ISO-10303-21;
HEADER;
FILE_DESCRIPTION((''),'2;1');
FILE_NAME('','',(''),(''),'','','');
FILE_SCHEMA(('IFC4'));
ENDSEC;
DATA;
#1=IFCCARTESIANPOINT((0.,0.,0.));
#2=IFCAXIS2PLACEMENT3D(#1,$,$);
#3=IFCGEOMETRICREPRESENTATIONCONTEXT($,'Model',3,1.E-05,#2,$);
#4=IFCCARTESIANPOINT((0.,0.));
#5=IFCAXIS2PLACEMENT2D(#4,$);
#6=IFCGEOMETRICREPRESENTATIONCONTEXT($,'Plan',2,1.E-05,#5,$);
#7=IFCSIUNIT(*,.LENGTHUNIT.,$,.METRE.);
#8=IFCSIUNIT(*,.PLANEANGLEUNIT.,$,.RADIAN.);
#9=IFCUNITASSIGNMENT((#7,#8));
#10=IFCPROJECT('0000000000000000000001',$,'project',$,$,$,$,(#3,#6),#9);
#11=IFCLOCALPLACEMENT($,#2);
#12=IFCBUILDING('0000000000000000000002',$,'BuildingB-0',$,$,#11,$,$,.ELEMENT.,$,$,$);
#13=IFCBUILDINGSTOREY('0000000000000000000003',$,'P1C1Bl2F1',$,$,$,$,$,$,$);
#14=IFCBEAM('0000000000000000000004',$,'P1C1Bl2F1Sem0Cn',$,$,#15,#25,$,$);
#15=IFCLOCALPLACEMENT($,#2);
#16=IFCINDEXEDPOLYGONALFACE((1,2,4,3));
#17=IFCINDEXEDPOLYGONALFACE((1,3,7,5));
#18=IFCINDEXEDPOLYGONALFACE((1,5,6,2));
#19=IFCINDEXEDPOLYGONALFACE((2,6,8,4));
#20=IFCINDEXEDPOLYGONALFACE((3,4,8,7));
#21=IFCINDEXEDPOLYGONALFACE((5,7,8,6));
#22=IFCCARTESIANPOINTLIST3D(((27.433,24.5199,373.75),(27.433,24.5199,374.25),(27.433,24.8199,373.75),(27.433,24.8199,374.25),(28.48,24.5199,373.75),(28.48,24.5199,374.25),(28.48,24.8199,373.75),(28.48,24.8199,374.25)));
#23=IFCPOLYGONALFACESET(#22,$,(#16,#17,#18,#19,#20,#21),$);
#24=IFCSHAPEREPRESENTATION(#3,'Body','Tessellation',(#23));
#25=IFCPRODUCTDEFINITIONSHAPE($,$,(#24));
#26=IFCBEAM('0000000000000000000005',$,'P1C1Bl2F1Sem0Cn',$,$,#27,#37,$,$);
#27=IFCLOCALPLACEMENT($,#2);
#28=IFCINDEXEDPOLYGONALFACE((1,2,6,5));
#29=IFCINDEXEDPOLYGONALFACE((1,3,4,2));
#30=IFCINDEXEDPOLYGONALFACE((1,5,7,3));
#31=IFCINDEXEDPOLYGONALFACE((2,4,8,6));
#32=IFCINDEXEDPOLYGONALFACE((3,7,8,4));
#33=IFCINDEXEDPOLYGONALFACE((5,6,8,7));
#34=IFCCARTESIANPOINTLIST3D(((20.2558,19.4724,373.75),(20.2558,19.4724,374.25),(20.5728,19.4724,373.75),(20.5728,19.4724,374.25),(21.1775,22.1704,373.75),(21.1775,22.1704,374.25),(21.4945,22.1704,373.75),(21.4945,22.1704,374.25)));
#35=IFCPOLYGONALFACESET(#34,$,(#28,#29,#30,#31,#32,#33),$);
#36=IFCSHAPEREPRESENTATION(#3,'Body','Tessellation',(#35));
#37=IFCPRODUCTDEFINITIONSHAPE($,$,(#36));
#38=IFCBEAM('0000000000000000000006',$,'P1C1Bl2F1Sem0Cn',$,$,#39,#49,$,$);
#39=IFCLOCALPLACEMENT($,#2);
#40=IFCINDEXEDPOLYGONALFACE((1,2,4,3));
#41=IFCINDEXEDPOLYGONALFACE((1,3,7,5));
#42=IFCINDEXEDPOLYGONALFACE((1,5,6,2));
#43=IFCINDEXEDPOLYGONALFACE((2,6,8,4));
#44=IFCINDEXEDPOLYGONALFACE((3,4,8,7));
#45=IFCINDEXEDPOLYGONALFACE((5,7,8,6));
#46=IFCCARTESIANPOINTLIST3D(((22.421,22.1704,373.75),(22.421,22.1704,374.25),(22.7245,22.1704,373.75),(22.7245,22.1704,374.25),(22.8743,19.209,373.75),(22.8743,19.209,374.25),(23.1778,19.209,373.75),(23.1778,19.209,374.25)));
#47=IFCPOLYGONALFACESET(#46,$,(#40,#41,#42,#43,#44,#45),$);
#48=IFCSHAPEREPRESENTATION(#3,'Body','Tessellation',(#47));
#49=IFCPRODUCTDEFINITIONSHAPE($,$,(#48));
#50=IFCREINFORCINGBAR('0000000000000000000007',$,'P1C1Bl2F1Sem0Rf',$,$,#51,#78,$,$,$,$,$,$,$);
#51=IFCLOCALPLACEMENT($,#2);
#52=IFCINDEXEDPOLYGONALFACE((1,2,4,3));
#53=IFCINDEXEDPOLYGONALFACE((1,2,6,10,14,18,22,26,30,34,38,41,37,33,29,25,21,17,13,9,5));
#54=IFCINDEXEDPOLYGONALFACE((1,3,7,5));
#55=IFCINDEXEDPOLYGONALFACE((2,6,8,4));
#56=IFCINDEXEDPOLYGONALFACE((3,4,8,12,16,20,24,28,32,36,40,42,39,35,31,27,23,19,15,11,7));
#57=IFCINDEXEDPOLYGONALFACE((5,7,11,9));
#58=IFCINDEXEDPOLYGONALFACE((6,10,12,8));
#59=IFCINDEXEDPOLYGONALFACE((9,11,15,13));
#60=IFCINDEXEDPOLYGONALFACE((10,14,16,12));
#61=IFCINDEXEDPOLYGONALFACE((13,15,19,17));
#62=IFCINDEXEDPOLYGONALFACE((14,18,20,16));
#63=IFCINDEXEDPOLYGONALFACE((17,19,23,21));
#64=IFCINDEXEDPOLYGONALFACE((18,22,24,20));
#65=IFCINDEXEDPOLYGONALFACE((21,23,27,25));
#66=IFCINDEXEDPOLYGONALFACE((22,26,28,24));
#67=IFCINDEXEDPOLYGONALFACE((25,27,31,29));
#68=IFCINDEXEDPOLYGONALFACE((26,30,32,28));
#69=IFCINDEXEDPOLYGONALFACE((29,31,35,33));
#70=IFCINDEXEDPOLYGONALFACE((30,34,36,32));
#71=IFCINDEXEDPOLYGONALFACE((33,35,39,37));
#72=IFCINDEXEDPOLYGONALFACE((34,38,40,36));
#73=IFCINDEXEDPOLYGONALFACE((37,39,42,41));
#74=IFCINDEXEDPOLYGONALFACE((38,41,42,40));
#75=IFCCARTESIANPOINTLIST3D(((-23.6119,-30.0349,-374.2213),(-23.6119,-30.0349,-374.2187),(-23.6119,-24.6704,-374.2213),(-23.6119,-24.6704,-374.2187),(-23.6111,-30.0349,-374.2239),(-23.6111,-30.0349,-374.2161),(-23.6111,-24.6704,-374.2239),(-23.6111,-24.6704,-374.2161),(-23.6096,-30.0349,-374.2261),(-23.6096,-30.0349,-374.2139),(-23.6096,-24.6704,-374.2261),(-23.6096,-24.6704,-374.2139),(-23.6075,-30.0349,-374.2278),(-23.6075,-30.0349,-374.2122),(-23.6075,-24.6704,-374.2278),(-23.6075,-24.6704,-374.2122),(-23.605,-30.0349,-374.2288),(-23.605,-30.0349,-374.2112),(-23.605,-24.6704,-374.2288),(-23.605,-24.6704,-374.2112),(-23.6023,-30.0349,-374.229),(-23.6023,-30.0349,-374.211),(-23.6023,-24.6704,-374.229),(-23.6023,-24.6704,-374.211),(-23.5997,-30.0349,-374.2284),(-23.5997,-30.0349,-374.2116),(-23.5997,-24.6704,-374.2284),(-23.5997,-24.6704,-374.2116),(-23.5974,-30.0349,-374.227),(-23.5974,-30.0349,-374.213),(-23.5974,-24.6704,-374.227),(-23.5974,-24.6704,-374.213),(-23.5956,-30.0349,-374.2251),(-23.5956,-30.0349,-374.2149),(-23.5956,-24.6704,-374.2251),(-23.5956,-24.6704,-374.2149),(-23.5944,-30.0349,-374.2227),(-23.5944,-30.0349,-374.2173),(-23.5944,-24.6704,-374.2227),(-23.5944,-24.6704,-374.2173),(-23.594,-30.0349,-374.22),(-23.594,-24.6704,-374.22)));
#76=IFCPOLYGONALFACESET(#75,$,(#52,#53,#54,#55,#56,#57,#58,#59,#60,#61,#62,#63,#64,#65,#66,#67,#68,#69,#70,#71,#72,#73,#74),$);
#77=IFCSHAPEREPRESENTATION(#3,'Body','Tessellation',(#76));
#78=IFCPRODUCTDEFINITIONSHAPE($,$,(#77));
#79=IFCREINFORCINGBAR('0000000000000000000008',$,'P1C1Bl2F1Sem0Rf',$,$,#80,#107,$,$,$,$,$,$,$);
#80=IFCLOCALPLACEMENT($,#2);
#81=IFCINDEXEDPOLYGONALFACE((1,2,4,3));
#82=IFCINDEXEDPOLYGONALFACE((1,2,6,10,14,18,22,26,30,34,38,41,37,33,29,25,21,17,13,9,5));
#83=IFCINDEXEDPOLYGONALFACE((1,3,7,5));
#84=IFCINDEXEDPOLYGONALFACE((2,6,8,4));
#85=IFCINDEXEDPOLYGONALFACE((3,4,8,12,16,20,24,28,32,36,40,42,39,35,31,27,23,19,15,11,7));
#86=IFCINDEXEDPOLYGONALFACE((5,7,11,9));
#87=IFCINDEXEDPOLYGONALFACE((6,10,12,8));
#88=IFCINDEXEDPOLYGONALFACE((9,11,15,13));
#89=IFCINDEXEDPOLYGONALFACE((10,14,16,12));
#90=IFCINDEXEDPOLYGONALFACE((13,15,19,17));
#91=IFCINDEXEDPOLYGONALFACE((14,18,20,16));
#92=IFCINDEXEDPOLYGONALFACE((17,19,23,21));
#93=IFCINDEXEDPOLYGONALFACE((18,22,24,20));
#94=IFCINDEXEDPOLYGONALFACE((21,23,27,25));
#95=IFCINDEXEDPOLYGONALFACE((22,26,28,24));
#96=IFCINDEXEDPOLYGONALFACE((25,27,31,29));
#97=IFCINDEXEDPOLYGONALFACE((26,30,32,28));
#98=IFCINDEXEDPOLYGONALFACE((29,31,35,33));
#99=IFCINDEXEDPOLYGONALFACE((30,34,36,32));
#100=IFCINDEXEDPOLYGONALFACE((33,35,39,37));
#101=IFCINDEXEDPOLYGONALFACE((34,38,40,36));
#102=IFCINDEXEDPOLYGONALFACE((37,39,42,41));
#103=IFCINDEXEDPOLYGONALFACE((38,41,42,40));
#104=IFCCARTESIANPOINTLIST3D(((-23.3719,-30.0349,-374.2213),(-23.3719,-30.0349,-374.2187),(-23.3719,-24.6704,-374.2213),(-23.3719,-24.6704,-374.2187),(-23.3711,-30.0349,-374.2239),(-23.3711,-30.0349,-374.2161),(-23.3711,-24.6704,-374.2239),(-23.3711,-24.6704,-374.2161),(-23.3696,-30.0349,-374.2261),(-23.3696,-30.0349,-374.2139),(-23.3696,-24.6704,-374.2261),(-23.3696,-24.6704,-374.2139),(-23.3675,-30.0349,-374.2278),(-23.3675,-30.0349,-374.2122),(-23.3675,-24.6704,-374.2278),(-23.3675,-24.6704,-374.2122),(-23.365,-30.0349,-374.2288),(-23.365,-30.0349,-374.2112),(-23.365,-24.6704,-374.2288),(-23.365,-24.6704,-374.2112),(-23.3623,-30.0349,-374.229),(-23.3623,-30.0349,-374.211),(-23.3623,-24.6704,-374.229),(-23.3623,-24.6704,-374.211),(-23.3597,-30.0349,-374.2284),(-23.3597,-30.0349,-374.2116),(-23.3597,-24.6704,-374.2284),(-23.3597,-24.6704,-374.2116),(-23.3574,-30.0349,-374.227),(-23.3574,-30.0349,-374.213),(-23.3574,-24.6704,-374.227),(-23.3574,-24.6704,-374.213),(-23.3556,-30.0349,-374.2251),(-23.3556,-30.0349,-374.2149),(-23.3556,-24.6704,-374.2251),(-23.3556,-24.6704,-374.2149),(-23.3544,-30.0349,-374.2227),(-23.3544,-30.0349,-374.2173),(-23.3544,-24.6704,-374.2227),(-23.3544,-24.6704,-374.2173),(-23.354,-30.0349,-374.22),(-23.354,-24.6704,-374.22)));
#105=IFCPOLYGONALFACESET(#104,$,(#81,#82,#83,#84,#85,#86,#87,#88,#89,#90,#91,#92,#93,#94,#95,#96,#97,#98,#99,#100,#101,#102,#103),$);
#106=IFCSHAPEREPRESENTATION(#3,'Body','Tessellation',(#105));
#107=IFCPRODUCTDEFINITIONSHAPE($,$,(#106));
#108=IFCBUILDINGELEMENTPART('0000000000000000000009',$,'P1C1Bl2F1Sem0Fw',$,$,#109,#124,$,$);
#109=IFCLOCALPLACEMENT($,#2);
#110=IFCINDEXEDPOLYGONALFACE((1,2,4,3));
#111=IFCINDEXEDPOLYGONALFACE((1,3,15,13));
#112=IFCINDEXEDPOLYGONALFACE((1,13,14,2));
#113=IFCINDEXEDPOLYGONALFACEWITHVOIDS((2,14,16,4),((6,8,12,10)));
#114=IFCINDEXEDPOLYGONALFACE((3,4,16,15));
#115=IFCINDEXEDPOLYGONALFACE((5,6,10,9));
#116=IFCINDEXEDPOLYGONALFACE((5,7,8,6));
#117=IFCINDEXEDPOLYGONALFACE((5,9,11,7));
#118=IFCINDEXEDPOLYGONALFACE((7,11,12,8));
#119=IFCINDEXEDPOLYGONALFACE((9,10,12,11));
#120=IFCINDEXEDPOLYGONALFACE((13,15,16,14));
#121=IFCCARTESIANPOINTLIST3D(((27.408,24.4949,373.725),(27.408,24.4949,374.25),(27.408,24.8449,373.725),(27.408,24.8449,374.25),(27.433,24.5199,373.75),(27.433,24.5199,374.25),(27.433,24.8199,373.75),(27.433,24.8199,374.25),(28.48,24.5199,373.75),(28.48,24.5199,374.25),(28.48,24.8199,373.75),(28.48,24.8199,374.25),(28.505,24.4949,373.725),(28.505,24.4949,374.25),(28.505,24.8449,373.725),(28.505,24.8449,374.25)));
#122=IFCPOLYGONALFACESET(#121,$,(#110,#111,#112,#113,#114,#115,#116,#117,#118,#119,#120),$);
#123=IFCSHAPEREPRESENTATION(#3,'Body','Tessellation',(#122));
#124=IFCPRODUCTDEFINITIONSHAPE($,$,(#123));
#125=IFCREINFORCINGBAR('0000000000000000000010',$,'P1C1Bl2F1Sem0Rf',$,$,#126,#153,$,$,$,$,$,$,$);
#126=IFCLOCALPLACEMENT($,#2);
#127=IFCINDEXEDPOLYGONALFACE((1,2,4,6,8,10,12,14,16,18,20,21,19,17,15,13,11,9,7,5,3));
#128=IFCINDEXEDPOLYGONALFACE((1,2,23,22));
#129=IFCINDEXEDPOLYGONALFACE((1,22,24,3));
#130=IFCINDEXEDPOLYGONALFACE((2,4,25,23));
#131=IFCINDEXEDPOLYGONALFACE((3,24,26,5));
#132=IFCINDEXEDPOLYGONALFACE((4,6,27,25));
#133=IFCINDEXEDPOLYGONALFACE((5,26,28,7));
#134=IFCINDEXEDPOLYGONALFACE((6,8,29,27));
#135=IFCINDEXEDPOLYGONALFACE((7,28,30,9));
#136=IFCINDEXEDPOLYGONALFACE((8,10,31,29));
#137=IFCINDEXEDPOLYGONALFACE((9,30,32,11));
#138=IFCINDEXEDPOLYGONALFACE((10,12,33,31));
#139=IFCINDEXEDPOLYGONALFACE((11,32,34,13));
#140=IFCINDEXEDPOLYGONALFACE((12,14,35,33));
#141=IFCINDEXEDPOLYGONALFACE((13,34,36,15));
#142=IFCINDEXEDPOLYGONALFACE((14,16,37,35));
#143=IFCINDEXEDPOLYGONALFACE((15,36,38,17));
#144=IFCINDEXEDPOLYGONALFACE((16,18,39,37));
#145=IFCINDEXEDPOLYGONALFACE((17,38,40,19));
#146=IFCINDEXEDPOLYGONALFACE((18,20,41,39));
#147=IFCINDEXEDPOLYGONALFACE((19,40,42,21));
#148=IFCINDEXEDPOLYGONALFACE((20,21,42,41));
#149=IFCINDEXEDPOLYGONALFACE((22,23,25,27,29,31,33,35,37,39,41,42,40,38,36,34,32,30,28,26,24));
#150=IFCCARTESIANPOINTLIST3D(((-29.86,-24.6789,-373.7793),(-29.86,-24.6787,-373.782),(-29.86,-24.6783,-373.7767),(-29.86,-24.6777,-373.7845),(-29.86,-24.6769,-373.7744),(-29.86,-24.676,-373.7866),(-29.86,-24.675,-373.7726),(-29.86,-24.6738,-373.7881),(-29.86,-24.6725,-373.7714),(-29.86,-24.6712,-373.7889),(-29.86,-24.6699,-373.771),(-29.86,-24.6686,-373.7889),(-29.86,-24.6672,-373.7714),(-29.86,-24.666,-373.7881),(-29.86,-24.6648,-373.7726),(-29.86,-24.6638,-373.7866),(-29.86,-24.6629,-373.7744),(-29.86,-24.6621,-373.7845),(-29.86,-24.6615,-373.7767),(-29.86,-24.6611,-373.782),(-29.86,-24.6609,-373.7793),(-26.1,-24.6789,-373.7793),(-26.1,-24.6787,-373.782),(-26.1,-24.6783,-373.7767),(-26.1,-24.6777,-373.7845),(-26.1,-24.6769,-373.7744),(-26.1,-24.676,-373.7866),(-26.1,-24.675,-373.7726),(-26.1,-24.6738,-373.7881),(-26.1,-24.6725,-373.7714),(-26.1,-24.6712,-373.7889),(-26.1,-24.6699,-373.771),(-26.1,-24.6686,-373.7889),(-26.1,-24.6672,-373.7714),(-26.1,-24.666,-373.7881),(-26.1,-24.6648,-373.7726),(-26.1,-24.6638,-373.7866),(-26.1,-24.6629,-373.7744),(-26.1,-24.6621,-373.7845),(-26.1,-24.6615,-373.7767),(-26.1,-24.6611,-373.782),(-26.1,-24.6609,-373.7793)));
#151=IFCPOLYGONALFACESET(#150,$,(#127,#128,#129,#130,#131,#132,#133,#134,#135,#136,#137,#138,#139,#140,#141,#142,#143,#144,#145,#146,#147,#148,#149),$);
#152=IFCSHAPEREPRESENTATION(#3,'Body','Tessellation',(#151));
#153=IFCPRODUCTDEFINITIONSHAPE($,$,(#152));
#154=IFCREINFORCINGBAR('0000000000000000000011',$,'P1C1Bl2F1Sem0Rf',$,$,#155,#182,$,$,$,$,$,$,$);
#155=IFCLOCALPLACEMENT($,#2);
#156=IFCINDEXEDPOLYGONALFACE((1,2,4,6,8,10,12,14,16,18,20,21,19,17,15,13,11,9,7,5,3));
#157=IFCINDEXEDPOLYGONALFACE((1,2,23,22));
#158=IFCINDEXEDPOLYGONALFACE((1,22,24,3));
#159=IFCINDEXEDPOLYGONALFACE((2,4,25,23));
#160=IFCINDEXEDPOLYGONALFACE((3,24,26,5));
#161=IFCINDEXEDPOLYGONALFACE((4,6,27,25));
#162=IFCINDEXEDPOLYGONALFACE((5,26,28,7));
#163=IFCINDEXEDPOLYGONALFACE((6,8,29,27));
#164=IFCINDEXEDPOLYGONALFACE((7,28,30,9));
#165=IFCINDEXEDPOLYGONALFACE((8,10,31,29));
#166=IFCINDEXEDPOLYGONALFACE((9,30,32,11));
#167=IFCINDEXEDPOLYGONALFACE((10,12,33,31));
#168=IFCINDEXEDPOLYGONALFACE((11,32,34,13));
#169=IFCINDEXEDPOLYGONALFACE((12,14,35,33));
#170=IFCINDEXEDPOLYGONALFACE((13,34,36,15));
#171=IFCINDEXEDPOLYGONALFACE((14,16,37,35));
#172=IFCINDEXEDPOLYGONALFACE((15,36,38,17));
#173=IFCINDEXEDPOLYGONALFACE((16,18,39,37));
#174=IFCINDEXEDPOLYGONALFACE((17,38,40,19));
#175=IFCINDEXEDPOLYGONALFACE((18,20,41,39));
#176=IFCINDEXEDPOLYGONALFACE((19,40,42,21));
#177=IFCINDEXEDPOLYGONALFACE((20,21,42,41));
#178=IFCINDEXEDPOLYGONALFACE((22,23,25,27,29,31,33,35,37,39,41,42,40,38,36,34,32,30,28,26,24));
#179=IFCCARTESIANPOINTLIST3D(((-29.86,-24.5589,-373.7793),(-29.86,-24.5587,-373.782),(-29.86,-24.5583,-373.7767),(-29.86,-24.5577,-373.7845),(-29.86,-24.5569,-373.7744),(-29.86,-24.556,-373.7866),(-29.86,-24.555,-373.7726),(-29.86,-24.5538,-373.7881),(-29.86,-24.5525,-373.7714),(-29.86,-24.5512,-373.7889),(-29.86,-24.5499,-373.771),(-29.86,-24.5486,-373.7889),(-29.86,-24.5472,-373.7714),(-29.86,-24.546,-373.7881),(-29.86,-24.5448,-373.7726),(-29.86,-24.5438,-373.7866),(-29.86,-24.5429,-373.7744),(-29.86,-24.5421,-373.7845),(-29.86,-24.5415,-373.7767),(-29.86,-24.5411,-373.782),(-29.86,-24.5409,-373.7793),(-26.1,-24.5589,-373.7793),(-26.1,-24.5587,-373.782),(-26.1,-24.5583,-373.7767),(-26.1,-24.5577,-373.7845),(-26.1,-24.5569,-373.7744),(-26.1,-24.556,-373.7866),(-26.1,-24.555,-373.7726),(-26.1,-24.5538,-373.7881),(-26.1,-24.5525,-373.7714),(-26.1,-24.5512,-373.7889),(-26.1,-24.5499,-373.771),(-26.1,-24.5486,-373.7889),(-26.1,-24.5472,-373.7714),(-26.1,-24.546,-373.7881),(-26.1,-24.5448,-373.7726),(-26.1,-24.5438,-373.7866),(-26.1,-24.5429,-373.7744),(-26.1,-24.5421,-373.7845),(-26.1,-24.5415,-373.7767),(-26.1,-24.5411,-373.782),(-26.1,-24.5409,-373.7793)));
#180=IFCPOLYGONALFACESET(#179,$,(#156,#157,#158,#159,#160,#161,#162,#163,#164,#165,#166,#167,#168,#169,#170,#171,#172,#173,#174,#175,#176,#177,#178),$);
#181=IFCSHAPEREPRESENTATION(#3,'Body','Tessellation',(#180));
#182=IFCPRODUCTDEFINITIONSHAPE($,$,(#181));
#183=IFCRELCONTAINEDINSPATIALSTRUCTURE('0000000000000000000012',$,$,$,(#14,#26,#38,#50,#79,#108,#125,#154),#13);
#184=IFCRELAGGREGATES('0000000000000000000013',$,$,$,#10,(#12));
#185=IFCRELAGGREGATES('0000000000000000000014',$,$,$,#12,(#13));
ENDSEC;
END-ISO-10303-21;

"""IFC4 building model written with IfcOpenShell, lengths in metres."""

from ifc_helpers import new_model, entity, si_unit, origin, origin_2d, place, context, project, spatial, polyline, outline, extrude, element, save


model = new_model("IFC4")

# Units and contexts
model_context = context("Model", 3, precision=1e-05, world=origin())
plan_context = context("Plan", 2, precision=1e-05, world=origin_2d())
ifc_project = project(units=[si_unit("LENGTHUNIT", "METRE"), si_unit("PLANEANGLEUNIT", "RADIAN")], contexts=[model_context, plan_context])

# Building, storey
building_placement = place(None, origin())
building = spatial("IfcBuilding", under=ifc_project, at=building_placement, Name="BuildingB-0", CompositionType="ELEMENT")
storey = spatial("IfcBuildingStorey", under=building, Name="P1C1Bl2F1")

# Beams
element("IfcBeam", 1, inside=storey, Name="P1C1Bl2F1Sem0Cn", context=model_context, shape_type="SweptSolid", body=[
    extrude(outline(polyline([(27.433, 24.5199, 373.75), (27.433, 24.8199, 373.75), (28.48, 24.8199, 373.75), (28.48, 24.5199, 373.75), (27.433, 24.5199, 373.75)])), None, (0.0, 0.0, 1.0), 0.5),
])
element("IfcBeam", 2, inside=storey, Name="P1C1Bl2F1Sem0Cn", context=model_context, shape_type="SweptSolid", body=[
    extrude(outline(polyline([(20.2558, 19.4724, 373.75), (20.5728, 19.4724, 373.75), (21.4945, 22.1704, 373.75), (21.1775, 22.1704, 373.75), (20.2558, 19.4724, 373.75)])), None, (0.0, 0.0, 1.0), 0.5),
])
element("IfcBeam", 3, inside=storey, Name="P1C1Bl2F1Sem0Cn", context=model_context, shape_type="SweptSolid", body=[
    extrude(outline(polyline([(22.8743, 19.209, 373.75), (23.1778, 19.209, 373.75), (22.7245, 22.1704, 373.75), (22.421, 22.1704, 373.75), (22.8743, 19.209, 373.75)])), None, (0.0, 0.0, 1.0), 0.5),
])

# Reinforcing bars
element("IfcReinforcingBar", 4, inside=storey, Name="P1C1Bl2F1Sem0Rf", context=model_context, shape_type="SweptSolid", body=[
    entity("IfcSurfaceCurveSweptAreaSolid", entity("IfcCircleProfileDef", "AREA", None, None, 0.009), None, entity("IfcPolyline", [entity("IfcCartesianPoint", [23.603, 24.6704, 374.22]), entity("IfcCartesianPoint", [23.603, 30.0349, 374.22])]), None, None, entity("IfcPlane", entity("IfcAxis2Placement3D", entity("IfcCartesianPoint", [23.603, 24.6704, 374.22]), entity("IfcDirection", [0.0, 0.0, 1.0]), entity("IfcDirection", [1.0, 0.0, 0.0])))),
])
element("IfcReinforcingBar", 5, inside=storey, Name="P1C1Bl2F1Sem0Rf", context=model_context, shape_type="SweptSolid", body=[
    entity("IfcSurfaceCurveSweptAreaSolid", entity("IfcCircleProfileDef", "AREA", None, None, 0.009), None, entity("IfcPolyline", [entity("IfcCartesianPoint", [23.363, 24.6704, 374.22]), entity("IfcCartesianPoint", [23.363, 30.0349, 374.22])]), None, None, entity("IfcPlane", entity("IfcAxis2Placement3D", entity("IfcCartesianPoint", [23.363, 24.6704, 374.22]), entity("IfcDirection", [0.0, 0.0, 1.0]), entity("IfcDirection", [1.0, 0.0, 0.0])))),
])

# Building element part, opening
building_element_part_1 = element("IfcBuildingElementPart", 6, inside=storey, Name="P1C1Bl2F1Sem0Fw", context=model_context, shape_type="SweptSolid", body=[
    extrude(outline(polyline([(27.408, 24.4949, 373.725), (27.408, 24.8449, 373.725), (28.505, 24.8449, 373.725), (28.505, 24.4949, 373.725), (27.408, 24.4949, 373.725)])), None, (0.0, 0.0, 1.0), 0.525),
])
element("IfcOpeningElement", 7, inside=storey, cuts=building_element_part_1, context=model_context, shape_type="SweptSolid", body=[
    extrude(outline(polyline([(27.433, 24.5199, 373.75), (27.433, 24.8199, 373.75), (28.48, 24.8199, 373.75), (28.48, 24.5199, 373.75), (27.433, 24.5199, 373.75)])), None, (0.0, 0.0, 1.0), 0.5),
])

# Reinforcing bars
element("IfcReinforcingBar", 8, inside=storey, Name="P1C1Bl2F1Sem0Rf", context=model_context, shape_type="SweptSolid", body=[
    entity("IfcSurfaceCurveSweptAreaSolid", entity("IfcCircleProfileDef", "AREA", None, None, 0.009), None, entity("IfcPolyline", [entity("IfcCartesianPoint", [26.1, 24.6699, 373.78]), entity("IfcCartesianPoint", [29.86, 24.6699, 373.78])]), None, None, entity("IfcPlane", entity("IfcAxis2Placement3D", entity("IfcCartesianPoint", [26.1, 24.6699, 373.78]), entity("IfcDirection", [0.0, 0.0, 1.0]), entity("IfcDirection", [1.0, 0.0, 0.0])))),
])
element("IfcReinforcingBar", 9, inside=storey, Name="P1C1Bl2F1Sem0Rf", context=model_context, shape_type="SweptSolid", body=[
    entity("IfcSurfaceCurveSweptAreaSolid", entity("IfcCircleProfileDef", "AREA", None, None, 0.009), None, entity("IfcPolyline", [entity("IfcCartesianPoint", [26.1, 24.5499, 373.78]), entity("IfcCartesianPoint", [29.86, 24.5499, 373.78])]), None, None, entity("IfcPlane", entity("IfcAxis2Placement3D", entity("IfcCartesianPoint", [26.1, 24.5499, 373.78]), entity("IfcDirection", [0.0, 0.0, 1.0]), entity("IfcDirection", [1.0, 0.0, 0.0])))),
])

save(model, "model.ifc")
